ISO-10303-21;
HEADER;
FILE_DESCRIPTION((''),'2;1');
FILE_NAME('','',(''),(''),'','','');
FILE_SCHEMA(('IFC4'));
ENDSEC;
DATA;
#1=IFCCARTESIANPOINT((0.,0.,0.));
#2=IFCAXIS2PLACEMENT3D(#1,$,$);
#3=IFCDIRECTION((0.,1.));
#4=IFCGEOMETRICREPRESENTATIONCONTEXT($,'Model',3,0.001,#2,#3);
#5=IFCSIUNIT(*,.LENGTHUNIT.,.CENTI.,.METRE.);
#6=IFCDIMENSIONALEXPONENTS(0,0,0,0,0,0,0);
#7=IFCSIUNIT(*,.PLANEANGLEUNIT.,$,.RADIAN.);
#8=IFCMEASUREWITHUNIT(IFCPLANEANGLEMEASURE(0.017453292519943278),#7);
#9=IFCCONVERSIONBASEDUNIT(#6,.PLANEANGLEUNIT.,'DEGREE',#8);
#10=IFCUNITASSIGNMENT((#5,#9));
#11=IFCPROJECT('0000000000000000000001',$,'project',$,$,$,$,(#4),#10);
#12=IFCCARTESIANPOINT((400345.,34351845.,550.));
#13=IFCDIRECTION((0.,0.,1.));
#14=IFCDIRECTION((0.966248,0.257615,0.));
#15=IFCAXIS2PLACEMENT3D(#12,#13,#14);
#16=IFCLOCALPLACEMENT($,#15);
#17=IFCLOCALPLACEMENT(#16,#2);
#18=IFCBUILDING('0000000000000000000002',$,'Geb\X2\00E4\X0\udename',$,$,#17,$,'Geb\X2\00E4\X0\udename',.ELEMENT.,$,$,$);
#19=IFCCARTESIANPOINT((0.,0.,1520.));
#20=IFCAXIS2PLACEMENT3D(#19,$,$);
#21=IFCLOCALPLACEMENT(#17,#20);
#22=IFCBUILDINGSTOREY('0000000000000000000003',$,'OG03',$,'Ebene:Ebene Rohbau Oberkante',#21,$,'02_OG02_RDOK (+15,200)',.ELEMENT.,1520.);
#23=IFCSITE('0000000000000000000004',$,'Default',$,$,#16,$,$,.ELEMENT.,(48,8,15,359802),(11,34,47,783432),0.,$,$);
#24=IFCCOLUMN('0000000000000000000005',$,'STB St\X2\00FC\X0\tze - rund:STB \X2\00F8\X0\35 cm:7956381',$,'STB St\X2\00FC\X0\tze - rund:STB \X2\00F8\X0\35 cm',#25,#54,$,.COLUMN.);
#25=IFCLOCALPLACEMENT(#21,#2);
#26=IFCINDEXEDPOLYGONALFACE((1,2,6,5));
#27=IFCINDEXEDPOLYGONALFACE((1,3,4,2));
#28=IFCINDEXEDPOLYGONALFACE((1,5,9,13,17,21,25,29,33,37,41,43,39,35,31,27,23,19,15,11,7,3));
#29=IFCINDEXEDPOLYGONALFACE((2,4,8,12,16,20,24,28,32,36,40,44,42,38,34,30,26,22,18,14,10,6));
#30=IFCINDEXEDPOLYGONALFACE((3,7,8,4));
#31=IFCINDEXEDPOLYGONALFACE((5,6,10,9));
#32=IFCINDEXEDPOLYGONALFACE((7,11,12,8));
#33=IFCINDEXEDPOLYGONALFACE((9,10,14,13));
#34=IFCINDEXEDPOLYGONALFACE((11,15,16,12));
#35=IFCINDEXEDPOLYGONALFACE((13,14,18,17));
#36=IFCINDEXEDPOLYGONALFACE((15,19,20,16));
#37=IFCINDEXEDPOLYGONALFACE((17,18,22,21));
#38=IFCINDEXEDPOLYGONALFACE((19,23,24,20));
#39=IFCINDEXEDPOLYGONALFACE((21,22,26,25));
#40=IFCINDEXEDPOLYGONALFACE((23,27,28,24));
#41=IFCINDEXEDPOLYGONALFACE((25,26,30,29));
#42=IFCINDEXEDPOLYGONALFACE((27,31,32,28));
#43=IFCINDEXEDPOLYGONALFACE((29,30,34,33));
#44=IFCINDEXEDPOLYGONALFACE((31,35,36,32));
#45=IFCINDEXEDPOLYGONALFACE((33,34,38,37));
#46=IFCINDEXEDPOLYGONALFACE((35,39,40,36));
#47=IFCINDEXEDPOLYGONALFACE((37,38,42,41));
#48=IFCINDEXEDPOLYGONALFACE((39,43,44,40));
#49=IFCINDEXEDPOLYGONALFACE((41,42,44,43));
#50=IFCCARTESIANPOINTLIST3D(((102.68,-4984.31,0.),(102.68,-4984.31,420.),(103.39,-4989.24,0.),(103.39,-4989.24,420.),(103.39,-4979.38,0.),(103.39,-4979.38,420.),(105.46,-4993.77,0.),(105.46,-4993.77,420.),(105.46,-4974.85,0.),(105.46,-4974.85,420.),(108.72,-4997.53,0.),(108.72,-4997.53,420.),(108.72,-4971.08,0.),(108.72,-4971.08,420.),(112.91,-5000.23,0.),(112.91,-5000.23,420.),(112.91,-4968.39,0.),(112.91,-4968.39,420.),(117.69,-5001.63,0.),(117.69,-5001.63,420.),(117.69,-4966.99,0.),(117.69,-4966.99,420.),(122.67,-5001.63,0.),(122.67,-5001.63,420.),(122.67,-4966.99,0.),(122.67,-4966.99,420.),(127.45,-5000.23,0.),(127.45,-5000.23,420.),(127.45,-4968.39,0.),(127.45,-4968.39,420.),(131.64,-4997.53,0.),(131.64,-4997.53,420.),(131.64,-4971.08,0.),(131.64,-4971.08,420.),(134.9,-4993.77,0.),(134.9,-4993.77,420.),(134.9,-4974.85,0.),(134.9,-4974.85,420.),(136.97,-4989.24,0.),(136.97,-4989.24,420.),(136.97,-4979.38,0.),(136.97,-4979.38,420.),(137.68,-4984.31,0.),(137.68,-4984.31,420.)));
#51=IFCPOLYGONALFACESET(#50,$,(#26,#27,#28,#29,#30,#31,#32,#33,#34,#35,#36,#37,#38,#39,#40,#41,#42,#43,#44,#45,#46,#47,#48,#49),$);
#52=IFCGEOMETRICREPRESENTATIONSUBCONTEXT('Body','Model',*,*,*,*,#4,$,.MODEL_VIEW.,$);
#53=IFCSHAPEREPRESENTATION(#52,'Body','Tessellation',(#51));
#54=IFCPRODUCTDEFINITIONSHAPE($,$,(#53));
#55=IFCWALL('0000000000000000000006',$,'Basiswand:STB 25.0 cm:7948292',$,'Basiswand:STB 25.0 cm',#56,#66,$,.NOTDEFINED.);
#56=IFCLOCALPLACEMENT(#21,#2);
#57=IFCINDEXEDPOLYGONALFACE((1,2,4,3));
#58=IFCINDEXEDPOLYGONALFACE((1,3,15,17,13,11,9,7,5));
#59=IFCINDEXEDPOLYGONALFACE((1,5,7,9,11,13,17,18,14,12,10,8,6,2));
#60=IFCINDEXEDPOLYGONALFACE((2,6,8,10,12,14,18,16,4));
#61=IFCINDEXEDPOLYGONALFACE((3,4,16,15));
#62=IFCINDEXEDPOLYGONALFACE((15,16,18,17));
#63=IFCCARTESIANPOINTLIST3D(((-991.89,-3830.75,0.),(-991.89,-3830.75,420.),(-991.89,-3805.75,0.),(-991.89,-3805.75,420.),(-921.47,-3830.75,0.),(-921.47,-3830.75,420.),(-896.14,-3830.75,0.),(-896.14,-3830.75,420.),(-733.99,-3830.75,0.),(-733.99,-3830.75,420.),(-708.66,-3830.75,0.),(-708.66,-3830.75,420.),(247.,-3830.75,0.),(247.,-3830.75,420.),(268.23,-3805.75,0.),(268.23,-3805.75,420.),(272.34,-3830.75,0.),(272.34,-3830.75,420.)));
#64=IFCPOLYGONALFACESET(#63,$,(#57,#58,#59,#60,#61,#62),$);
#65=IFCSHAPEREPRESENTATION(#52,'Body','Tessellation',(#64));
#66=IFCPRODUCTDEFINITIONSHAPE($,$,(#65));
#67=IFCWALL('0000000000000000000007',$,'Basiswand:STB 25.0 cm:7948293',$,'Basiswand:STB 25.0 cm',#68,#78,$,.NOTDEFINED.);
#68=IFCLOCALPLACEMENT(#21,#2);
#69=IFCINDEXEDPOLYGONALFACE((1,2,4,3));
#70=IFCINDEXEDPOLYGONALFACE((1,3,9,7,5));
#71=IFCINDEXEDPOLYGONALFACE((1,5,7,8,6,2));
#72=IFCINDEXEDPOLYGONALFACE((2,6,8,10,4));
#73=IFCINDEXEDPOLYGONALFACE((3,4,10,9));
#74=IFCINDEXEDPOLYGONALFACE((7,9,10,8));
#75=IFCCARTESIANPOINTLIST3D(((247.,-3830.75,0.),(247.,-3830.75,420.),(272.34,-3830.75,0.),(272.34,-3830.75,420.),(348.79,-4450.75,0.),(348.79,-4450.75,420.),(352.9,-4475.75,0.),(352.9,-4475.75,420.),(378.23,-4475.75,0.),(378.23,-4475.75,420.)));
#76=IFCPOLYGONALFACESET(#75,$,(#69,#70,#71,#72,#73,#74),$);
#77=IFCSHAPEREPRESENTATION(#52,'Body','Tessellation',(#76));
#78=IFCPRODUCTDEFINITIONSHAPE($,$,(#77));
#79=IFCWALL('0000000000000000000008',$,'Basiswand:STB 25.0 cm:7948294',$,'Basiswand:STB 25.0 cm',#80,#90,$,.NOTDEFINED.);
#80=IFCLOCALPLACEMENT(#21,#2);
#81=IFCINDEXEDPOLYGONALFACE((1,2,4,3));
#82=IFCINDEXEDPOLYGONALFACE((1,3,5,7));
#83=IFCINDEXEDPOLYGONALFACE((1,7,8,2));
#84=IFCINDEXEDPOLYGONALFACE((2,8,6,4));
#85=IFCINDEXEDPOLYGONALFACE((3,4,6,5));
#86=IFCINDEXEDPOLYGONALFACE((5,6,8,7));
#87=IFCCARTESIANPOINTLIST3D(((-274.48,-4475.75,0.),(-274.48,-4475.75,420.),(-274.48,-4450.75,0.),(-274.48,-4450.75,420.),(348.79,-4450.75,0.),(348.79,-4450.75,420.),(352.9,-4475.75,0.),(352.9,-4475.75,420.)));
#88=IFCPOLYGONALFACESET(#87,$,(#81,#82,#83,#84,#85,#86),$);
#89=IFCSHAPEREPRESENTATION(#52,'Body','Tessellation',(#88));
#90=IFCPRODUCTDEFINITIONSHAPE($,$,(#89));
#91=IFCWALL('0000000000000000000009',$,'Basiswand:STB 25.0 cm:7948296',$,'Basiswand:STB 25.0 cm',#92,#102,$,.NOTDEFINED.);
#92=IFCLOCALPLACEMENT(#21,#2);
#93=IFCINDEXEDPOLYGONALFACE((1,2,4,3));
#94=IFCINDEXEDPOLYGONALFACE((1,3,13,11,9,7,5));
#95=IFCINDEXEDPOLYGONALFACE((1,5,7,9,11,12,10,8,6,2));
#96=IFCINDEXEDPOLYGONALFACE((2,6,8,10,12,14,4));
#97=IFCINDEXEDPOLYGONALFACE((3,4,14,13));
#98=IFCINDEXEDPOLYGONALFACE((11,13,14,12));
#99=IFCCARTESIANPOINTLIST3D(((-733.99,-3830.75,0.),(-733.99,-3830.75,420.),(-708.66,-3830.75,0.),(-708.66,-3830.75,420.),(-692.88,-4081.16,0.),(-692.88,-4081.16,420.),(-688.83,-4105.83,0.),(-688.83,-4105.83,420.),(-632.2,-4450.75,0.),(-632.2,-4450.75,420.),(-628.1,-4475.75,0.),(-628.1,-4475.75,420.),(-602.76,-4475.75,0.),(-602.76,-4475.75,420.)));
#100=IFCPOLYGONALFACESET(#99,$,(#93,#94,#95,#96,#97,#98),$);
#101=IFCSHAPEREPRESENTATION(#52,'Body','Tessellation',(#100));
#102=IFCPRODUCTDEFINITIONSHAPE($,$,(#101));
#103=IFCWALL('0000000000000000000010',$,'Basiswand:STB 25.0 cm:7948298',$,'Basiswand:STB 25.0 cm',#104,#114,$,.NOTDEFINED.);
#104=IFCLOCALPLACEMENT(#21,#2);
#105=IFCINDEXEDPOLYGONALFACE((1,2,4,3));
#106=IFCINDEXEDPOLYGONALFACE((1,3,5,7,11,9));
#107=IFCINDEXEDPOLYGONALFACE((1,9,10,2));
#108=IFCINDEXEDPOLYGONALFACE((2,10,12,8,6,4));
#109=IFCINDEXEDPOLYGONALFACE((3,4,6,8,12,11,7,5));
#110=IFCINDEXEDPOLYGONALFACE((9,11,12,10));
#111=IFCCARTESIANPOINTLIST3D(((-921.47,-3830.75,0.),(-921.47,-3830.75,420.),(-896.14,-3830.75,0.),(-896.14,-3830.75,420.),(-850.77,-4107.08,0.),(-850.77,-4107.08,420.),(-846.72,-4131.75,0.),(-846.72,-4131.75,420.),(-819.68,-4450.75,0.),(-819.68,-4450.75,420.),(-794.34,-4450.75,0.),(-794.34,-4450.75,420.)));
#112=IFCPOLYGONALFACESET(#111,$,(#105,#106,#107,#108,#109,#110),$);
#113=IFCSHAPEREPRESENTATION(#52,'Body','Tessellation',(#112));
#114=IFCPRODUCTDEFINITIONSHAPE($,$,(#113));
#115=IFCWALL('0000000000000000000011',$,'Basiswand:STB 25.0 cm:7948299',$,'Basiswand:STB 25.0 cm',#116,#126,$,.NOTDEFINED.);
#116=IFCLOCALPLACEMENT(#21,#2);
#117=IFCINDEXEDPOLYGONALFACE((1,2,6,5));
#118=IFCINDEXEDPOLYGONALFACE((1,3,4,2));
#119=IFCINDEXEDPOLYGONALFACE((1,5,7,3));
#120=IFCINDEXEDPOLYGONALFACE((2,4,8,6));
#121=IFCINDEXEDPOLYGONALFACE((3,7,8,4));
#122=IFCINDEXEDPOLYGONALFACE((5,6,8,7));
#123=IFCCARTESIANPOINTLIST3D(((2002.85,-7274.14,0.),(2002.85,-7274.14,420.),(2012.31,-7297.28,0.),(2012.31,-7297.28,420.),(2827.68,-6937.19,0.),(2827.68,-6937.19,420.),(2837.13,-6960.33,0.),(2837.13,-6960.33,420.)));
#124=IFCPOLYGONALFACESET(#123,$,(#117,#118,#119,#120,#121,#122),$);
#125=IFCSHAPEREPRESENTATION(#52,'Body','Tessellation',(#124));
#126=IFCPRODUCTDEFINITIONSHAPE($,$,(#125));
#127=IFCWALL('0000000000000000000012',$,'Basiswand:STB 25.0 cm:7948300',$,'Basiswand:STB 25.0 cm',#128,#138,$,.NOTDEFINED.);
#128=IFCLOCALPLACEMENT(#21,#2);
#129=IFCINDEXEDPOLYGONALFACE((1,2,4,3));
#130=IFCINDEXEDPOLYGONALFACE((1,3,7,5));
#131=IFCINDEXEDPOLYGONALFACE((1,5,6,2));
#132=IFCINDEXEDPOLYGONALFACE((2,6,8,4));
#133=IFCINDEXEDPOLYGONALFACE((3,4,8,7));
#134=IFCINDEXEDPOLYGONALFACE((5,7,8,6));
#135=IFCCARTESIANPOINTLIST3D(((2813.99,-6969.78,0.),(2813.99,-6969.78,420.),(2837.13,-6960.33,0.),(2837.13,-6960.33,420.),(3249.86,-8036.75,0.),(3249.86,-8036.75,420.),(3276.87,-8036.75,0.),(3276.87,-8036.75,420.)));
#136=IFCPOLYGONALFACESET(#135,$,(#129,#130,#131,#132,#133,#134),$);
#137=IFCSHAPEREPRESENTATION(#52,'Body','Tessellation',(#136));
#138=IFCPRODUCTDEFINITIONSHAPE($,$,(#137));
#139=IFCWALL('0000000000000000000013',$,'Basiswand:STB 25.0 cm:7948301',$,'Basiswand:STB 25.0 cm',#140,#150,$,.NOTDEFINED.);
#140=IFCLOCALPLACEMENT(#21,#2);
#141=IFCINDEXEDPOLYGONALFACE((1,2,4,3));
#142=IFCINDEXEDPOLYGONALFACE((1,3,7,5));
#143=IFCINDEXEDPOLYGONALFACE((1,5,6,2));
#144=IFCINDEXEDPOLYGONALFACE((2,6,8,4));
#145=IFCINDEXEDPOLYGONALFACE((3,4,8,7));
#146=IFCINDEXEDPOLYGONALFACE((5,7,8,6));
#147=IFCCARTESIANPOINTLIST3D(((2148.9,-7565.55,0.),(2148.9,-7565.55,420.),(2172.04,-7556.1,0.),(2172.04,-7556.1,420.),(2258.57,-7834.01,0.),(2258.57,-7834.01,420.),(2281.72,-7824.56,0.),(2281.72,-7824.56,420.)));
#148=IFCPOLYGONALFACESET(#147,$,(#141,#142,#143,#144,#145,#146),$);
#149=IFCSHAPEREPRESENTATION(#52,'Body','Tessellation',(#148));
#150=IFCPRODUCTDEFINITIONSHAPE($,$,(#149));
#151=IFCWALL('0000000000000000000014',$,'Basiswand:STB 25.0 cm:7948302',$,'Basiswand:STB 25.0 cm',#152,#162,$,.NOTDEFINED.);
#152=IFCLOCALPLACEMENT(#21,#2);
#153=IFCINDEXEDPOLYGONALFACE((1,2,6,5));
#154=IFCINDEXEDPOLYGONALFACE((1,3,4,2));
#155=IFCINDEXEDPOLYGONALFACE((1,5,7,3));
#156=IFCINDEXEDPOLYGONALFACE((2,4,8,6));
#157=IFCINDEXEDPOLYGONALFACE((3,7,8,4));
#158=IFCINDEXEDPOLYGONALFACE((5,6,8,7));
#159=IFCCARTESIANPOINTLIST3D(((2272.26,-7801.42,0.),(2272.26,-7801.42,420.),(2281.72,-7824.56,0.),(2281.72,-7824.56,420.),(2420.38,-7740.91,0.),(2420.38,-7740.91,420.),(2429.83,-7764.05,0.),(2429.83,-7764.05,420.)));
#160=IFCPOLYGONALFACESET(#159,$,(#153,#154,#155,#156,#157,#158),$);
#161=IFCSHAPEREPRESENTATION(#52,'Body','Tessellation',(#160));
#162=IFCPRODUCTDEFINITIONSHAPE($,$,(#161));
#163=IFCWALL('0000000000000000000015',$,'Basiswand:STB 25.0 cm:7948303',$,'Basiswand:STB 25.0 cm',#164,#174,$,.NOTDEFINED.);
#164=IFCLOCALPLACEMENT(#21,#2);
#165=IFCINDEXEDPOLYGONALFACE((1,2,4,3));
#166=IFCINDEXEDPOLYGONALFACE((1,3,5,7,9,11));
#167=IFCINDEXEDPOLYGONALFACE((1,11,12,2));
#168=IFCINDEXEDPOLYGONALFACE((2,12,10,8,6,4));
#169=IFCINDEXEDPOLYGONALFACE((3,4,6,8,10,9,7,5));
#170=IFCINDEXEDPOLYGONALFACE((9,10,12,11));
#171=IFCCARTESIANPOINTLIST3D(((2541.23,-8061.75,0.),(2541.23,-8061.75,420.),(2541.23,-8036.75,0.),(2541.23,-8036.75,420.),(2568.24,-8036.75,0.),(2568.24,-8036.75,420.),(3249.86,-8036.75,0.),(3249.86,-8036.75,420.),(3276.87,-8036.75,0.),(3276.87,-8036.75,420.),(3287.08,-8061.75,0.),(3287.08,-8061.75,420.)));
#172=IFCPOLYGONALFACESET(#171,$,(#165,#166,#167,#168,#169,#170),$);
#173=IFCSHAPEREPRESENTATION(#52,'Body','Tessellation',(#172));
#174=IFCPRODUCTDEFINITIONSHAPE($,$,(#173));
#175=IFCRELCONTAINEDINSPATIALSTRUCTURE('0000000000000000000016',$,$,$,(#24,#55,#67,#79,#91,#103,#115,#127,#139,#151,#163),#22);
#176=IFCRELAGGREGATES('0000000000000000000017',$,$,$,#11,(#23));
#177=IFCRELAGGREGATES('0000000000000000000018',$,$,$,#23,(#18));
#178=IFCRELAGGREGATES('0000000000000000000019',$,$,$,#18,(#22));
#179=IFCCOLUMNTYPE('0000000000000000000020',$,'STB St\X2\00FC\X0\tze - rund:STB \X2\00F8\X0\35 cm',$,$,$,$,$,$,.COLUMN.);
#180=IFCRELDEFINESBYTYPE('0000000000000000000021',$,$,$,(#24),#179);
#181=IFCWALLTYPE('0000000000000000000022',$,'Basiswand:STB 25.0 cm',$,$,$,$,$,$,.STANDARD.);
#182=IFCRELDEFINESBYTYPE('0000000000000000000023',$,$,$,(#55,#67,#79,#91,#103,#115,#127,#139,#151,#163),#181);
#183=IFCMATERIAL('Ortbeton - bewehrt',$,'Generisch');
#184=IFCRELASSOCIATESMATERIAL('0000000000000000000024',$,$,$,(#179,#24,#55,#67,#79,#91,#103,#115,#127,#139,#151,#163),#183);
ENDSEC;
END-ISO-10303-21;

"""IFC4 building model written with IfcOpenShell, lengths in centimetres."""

from ifc_helpers import new_model, entity, si_unit, converted_unit, direction, frame, origin, place, context, subcontext, project, spatial, arc, indexed_curve, outline, extrude, source, transform, mapped, material, type_object, type_shapes, element, save


model = new_model("IFC4")

# Units and contexts
model_context = context("Model", 3, precision=0.001, world=origin(), true_north=direction((0.0, 1.0)))
body_context = subcontext(model_context, "Body", "Model", "MODEL_VIEW")
ifc_project = project(units=[si_unit("LENGTHUNIT", "METRE", prefix="CENTI"), converted_unit("PLANEANGLEUNIT", "DEGREE", entity("IfcPlaneAngleMeasure", 0.017453292519943278), si_unit("PLANEANGLEUNIT", "RADIAN"), dimensions=[0, 0, 0, 0, 0, 0, 0])], contexts=[model_context])

# Site, building, storey
site_placement = place(None, frame((400345.0, 34351845.0, 550.0), z_axis=(0.0, 0.0, 1.0), x_axis=(0.966248, 0.257615, 0.0)))
site = spatial("IfcSite", under=ifc_project, at=site_placement, Name="Default", CompositionType="ELEMENT", RefLatitude=(48, 8, 15, 359802), RefLongitude=(11, 34, 47, 783432), RefElevation=0.0)
building_placement = place(site_placement, origin())
building = spatial("IfcBuilding", under=site, at=building_placement, Name="Gebäudename", LongName="Gebäudename", CompositionType="ELEMENT")
storey_placement = place(building_placement, frame((0.0, 0.0, 1520.0)))
storey = spatial("IfcBuildingStorey", under=building, at=storey_placement, Name="OG03", ObjectType="Ebene:Ebene Rohbau Oberkante", LongName="02_OG02_RDOK (+15,200)", CompositionType="ELEMENT", Elevation=1520.0)

# Column
ifc_material = material(Name="Ortbeton - bewehrt", Category="Generisch")
column_type_1 = type_object("IfcColumnType", Name="STB Stütze - rund:STB ø35 cm", PredefinedType="COLUMN", material=ifc_material)
shared_shape_1 = source(origin(), body_context, "Body", "SweptSolid", [
    extrude(outline(indexed_curve([(-17.5, 0.0), (0.0, -17.5), (17.5, 0.0), (0.0, 17.5)], segments=[arc(1, 2, 3), arc(3, 4, 1)], self_intersect=False)), frame((120.18, -4984.31, 1520.0)), (0.0, 0.0, 1.0), 420.0),
])
type_shapes(column_type_1, [shared_shape_1])
column_1_placement = place(storey_placement, frame((0.0, 0.0, -1520.0)))
element("IfcColumn", 1, at=column_1_placement, inside=storey, type_object=column_type_1, material=ifc_material, Name="STB Stütze - rund:STB ø35 cm:7956381", ObjectType="STB Stütze - rund:STB ø35 cm", PredefinedType="COLUMN", context=body_context, shape_type="MappedRepresentation", body=[
    mapped(shared_shape_1, transform((0.0, 0.0, 0.0), scale=1.0)),
])

# Walls
wall_type = type_object("IfcWallType", Name="Basiswand:STB 25.0 cm", PredefinedType="STANDARD")
wall_1_placement = place(storey_placement, frame((-991.89, -3818.25, 0.0)))
element("IfcWall", 2, at=wall_1_placement, inside=storey, type_object=wall_type, material=ifc_material, Name="Basiswand:STB 25.0 cm:7948292", ObjectType="Basiswand:STB 25.0 cm", PredefinedType="NOTDEFINED", context=body_context, shape_type="SweptSolid", body=[
    extrude(outline(indexed_curve([(1264.23, -12.5), (1260.13, 12.5), (0.0, 12.5), (0.0, -12.5), (70.42, -12.5), (95.76, -12.5), (257.9, -12.5), (283.24, -12.5), (1238.9, -12.5), (1264.23, -12.5)], self_intersect=False)), origin(), (0.0, 0.0, 1.0), 420.0),
])
wall_2_placement = place(storey_placement, frame((259.34, -3828.72, 0.0), z_axis=(0.0, 0.0, 1.0), x_axis=(0.162011, -0.986789, 0.0)))
element("IfcWall", 3, at=wall_2_placement, inside=storey, type_object=wall_type, material=ifc_material, Name="Basiswand:STB 25.0 cm:7948293", ObjectType="Basiswand:STB 25.0 cm", PredefinedType="NOTDEFINED", context=body_context, shape_type="SweptSolid", body=[
    extrude(outline(indexed_curve([(653.64, -12.5), (657.74, 12.5), (4.1, 12.5), (0.0, -12.5), (628.3, -12.5), (653.64, -12.5)], self_intersect=False)), origin(), (0.0, 0.0, 1.0), 420.0),
])
wall_3_placement = place(storey_placement, frame((352.9, -4463.25, 0.0), z_axis=(0.0, 0.0, 1.0), x_axis=(-1.0, 0.0, 0.0)))
element("IfcWall", 4, at=wall_3_placement, inside=storey, type_object=wall_type, material=ifc_material, Name="Basiswand:STB 25.0 cm:7948294", ObjectType="Basiswand:STB 25.0 cm", PredefinedType="NOTDEFINED", context=body_context, shape_type="SweptSolid", body=[
    extrude(outline(indexed_curve([(627.37, -12.5), (627.37, 12.5), (0.0, 12.5), (4.1, -12.5), (627.37, -12.5)], self_intersect=False)), origin(), (0.0, 0.0, 1.0), 420.0),
])
wall_4_placement = place(storey_placement, frame((-721.66, -3828.72, 0.0), z_axis=(0.0, 0.0, 1.0), x_axis=(0.162011, -0.986789, 0.0)))
element("IfcWall", 5, at=wall_4_placement, inside=storey, type_object=wall_type, material=ifc_material, Name="Basiswand:STB 25.0 cm:7948296", ObjectType="Basiswand:STB 25.0 cm", PredefinedType="NOTDEFINED", context=body_context, shape_type="SweptSolid", body=[
    extrude(outline(indexed_curve([(653.64, -12.5), (657.74, 12.5), (4.1, 12.5), (0.0, -12.5), (253.77, -12.5), (278.77, -12.5), (628.3, -12.5), (653.64, -12.5)], self_intersect=False)), origin(), (0.0, 0.0, 1.0), 420.0),
])
wall_5_placement = place(storey_placement, frame((-806.68, -4452.77, 0.0), z_axis=(0.0, 0.0, 1.0), x_axis=(-0.162011, 0.986789, 0.0)))
element("IfcWall", 6, at=wall_5_placement, inside=storey, type_object=wall_type, material=ifc_material, Name="Basiswand:STB 25.0 cm:7948298", ObjectType="Basiswand:STB 25.0 cm", PredefinedType="NOTDEFINED", context=body_context, shape_type="SweptSolid", body=[
    extrude(outline(indexed_curve([(628.3, -12.5), (632.41, 12.5), (4.1, 12.5), (0.0, -12.5), (323.26, -12.5), (348.26, -12.5), (628.3, -12.5)], self_intersect=False)), origin(), (0.0, 0.0, 1.0), 420.0),
])
wall_6_placement = place(storey_placement, frame((2007.58, -7285.71, 0.0), z_axis=(0.0, 0.0, 1.0), x_axis=(0.925734, 0.378175, 0.0)))
element("IfcWall", 7, at=wall_6_placement, inside=storey, type_object=wall_type, material=ifc_material, Name="Basiswand:STB 25.0 cm:7948299", ObjectType="Basiswand:STB 25.0 cm", PredefinedType="NOTDEFINED", context=body_context, shape_type="SweptSolid", body=[
    extrude(outline(indexed_curve([(891.0, 12.5), (0.0, 12.5), (0.0, -12.5), (891.0, -12.5), (891.0, 12.5)], self_intersect=False)), origin(), (0.0, 0.0, 1.0), 420.0),
])
wall_7_placement = place(storey_placement, frame((2825.56, -6965.06, 0.0), z_axis=(0.0, 0.0, 1.0), x_axis=(0.378175, -0.925734, 0.0)))
element("IfcWall", 8, at=wall_7_placement, inside=storey, type_object=wall_type, material=ifc_material, Name="Basiswand:STB 25.0 cm:7948300", ObjectType="Basiswand:STB 25.0 cm", PredefinedType="NOTDEFINED", context=body_context, shape_type="SweptSolid", body=[
    extrude(outline(indexed_curve([(1152.56, -12.5), (1162.77, 12.5), (0.0, 12.5), (0.0, -12.5), (1152.56, -12.5)], self_intersect=False)), origin(), (0.0, 0.0, 1.0), 420.0),
])
wall_8_placement = place(storey_placement, frame((2160.47, -7560.82, 0.0), z_axis=(0.0, 0.0, 1.0), x_axis=(0.378175, -0.925734, 0.0)))
element("IfcWall", 9, at=wall_8_placement, inside=storey, type_object=wall_type, material=ifc_material, Name="Basiswand:STB 25.0 cm:7948301", ObjectType="Basiswand:STB 25.0 cm", PredefinedType="NOTDEFINED", context=body_context, shape_type="SweptSolid", body=[
    extrude(outline(indexed_curve([(290.0, 12.5), (0.0, 12.5), (0.0, -12.5), (290.0, -12.5), (290.0, 12.5)], self_intersect=False)), origin(), (0.0, 0.0, 1.0), 420.0),
])
wall_9_placement = place(storey_placement, frame((2276.99, -7812.99, 0.0), z_axis=(0.0, 0.0, 1.0), x_axis=(0.925734, 0.378175, 0.0)))
element("IfcWall", 10, at=wall_9_placement, inside=storey, type_object=wall_type, material=ifc_material, Name="Basiswand:STB 25.0 cm:7948302", ObjectType="Basiswand:STB 25.0 cm", PredefinedType="NOTDEFINED", context=body_context, shape_type="SweptSolid", body=[
    extrude(outline(indexed_curve([(160.0, 12.5), (0.0, 12.5), (0.0, -12.5), (160.0, -12.5), (160.0, 12.5)], self_intersect=False)), origin(), (0.0, 0.0, 1.0), 420.0),
])
wall_10_placement = place(storey_placement, frame((3287.08, -8049.25, 0.0), z_axis=(0.0, 0.0, 1.0), x_axis=(-1.0, 0.0, 0.0)))
element("IfcWall", 11, at=wall_10_placement, inside=storey, type_object=wall_type, material=ifc_material, Name="Basiswand:STB 25.0 cm:7948303", ObjectType="Basiswand:STB 25.0 cm", PredefinedType="NOTDEFINED", context=body_context, shape_type="SweptSolid", body=[
    extrude(outline(indexed_curve([(745.85, -12.5), (745.85, 12.5), (0.0, 12.5), (10.21, -12.5), (37.22, -12.5), (718.84, -12.5), (745.85, -12.5)], self_intersect=False)), origin(), (0.0, 0.0, 1.0), 420.0),
])

save(model, "model.ifc")
